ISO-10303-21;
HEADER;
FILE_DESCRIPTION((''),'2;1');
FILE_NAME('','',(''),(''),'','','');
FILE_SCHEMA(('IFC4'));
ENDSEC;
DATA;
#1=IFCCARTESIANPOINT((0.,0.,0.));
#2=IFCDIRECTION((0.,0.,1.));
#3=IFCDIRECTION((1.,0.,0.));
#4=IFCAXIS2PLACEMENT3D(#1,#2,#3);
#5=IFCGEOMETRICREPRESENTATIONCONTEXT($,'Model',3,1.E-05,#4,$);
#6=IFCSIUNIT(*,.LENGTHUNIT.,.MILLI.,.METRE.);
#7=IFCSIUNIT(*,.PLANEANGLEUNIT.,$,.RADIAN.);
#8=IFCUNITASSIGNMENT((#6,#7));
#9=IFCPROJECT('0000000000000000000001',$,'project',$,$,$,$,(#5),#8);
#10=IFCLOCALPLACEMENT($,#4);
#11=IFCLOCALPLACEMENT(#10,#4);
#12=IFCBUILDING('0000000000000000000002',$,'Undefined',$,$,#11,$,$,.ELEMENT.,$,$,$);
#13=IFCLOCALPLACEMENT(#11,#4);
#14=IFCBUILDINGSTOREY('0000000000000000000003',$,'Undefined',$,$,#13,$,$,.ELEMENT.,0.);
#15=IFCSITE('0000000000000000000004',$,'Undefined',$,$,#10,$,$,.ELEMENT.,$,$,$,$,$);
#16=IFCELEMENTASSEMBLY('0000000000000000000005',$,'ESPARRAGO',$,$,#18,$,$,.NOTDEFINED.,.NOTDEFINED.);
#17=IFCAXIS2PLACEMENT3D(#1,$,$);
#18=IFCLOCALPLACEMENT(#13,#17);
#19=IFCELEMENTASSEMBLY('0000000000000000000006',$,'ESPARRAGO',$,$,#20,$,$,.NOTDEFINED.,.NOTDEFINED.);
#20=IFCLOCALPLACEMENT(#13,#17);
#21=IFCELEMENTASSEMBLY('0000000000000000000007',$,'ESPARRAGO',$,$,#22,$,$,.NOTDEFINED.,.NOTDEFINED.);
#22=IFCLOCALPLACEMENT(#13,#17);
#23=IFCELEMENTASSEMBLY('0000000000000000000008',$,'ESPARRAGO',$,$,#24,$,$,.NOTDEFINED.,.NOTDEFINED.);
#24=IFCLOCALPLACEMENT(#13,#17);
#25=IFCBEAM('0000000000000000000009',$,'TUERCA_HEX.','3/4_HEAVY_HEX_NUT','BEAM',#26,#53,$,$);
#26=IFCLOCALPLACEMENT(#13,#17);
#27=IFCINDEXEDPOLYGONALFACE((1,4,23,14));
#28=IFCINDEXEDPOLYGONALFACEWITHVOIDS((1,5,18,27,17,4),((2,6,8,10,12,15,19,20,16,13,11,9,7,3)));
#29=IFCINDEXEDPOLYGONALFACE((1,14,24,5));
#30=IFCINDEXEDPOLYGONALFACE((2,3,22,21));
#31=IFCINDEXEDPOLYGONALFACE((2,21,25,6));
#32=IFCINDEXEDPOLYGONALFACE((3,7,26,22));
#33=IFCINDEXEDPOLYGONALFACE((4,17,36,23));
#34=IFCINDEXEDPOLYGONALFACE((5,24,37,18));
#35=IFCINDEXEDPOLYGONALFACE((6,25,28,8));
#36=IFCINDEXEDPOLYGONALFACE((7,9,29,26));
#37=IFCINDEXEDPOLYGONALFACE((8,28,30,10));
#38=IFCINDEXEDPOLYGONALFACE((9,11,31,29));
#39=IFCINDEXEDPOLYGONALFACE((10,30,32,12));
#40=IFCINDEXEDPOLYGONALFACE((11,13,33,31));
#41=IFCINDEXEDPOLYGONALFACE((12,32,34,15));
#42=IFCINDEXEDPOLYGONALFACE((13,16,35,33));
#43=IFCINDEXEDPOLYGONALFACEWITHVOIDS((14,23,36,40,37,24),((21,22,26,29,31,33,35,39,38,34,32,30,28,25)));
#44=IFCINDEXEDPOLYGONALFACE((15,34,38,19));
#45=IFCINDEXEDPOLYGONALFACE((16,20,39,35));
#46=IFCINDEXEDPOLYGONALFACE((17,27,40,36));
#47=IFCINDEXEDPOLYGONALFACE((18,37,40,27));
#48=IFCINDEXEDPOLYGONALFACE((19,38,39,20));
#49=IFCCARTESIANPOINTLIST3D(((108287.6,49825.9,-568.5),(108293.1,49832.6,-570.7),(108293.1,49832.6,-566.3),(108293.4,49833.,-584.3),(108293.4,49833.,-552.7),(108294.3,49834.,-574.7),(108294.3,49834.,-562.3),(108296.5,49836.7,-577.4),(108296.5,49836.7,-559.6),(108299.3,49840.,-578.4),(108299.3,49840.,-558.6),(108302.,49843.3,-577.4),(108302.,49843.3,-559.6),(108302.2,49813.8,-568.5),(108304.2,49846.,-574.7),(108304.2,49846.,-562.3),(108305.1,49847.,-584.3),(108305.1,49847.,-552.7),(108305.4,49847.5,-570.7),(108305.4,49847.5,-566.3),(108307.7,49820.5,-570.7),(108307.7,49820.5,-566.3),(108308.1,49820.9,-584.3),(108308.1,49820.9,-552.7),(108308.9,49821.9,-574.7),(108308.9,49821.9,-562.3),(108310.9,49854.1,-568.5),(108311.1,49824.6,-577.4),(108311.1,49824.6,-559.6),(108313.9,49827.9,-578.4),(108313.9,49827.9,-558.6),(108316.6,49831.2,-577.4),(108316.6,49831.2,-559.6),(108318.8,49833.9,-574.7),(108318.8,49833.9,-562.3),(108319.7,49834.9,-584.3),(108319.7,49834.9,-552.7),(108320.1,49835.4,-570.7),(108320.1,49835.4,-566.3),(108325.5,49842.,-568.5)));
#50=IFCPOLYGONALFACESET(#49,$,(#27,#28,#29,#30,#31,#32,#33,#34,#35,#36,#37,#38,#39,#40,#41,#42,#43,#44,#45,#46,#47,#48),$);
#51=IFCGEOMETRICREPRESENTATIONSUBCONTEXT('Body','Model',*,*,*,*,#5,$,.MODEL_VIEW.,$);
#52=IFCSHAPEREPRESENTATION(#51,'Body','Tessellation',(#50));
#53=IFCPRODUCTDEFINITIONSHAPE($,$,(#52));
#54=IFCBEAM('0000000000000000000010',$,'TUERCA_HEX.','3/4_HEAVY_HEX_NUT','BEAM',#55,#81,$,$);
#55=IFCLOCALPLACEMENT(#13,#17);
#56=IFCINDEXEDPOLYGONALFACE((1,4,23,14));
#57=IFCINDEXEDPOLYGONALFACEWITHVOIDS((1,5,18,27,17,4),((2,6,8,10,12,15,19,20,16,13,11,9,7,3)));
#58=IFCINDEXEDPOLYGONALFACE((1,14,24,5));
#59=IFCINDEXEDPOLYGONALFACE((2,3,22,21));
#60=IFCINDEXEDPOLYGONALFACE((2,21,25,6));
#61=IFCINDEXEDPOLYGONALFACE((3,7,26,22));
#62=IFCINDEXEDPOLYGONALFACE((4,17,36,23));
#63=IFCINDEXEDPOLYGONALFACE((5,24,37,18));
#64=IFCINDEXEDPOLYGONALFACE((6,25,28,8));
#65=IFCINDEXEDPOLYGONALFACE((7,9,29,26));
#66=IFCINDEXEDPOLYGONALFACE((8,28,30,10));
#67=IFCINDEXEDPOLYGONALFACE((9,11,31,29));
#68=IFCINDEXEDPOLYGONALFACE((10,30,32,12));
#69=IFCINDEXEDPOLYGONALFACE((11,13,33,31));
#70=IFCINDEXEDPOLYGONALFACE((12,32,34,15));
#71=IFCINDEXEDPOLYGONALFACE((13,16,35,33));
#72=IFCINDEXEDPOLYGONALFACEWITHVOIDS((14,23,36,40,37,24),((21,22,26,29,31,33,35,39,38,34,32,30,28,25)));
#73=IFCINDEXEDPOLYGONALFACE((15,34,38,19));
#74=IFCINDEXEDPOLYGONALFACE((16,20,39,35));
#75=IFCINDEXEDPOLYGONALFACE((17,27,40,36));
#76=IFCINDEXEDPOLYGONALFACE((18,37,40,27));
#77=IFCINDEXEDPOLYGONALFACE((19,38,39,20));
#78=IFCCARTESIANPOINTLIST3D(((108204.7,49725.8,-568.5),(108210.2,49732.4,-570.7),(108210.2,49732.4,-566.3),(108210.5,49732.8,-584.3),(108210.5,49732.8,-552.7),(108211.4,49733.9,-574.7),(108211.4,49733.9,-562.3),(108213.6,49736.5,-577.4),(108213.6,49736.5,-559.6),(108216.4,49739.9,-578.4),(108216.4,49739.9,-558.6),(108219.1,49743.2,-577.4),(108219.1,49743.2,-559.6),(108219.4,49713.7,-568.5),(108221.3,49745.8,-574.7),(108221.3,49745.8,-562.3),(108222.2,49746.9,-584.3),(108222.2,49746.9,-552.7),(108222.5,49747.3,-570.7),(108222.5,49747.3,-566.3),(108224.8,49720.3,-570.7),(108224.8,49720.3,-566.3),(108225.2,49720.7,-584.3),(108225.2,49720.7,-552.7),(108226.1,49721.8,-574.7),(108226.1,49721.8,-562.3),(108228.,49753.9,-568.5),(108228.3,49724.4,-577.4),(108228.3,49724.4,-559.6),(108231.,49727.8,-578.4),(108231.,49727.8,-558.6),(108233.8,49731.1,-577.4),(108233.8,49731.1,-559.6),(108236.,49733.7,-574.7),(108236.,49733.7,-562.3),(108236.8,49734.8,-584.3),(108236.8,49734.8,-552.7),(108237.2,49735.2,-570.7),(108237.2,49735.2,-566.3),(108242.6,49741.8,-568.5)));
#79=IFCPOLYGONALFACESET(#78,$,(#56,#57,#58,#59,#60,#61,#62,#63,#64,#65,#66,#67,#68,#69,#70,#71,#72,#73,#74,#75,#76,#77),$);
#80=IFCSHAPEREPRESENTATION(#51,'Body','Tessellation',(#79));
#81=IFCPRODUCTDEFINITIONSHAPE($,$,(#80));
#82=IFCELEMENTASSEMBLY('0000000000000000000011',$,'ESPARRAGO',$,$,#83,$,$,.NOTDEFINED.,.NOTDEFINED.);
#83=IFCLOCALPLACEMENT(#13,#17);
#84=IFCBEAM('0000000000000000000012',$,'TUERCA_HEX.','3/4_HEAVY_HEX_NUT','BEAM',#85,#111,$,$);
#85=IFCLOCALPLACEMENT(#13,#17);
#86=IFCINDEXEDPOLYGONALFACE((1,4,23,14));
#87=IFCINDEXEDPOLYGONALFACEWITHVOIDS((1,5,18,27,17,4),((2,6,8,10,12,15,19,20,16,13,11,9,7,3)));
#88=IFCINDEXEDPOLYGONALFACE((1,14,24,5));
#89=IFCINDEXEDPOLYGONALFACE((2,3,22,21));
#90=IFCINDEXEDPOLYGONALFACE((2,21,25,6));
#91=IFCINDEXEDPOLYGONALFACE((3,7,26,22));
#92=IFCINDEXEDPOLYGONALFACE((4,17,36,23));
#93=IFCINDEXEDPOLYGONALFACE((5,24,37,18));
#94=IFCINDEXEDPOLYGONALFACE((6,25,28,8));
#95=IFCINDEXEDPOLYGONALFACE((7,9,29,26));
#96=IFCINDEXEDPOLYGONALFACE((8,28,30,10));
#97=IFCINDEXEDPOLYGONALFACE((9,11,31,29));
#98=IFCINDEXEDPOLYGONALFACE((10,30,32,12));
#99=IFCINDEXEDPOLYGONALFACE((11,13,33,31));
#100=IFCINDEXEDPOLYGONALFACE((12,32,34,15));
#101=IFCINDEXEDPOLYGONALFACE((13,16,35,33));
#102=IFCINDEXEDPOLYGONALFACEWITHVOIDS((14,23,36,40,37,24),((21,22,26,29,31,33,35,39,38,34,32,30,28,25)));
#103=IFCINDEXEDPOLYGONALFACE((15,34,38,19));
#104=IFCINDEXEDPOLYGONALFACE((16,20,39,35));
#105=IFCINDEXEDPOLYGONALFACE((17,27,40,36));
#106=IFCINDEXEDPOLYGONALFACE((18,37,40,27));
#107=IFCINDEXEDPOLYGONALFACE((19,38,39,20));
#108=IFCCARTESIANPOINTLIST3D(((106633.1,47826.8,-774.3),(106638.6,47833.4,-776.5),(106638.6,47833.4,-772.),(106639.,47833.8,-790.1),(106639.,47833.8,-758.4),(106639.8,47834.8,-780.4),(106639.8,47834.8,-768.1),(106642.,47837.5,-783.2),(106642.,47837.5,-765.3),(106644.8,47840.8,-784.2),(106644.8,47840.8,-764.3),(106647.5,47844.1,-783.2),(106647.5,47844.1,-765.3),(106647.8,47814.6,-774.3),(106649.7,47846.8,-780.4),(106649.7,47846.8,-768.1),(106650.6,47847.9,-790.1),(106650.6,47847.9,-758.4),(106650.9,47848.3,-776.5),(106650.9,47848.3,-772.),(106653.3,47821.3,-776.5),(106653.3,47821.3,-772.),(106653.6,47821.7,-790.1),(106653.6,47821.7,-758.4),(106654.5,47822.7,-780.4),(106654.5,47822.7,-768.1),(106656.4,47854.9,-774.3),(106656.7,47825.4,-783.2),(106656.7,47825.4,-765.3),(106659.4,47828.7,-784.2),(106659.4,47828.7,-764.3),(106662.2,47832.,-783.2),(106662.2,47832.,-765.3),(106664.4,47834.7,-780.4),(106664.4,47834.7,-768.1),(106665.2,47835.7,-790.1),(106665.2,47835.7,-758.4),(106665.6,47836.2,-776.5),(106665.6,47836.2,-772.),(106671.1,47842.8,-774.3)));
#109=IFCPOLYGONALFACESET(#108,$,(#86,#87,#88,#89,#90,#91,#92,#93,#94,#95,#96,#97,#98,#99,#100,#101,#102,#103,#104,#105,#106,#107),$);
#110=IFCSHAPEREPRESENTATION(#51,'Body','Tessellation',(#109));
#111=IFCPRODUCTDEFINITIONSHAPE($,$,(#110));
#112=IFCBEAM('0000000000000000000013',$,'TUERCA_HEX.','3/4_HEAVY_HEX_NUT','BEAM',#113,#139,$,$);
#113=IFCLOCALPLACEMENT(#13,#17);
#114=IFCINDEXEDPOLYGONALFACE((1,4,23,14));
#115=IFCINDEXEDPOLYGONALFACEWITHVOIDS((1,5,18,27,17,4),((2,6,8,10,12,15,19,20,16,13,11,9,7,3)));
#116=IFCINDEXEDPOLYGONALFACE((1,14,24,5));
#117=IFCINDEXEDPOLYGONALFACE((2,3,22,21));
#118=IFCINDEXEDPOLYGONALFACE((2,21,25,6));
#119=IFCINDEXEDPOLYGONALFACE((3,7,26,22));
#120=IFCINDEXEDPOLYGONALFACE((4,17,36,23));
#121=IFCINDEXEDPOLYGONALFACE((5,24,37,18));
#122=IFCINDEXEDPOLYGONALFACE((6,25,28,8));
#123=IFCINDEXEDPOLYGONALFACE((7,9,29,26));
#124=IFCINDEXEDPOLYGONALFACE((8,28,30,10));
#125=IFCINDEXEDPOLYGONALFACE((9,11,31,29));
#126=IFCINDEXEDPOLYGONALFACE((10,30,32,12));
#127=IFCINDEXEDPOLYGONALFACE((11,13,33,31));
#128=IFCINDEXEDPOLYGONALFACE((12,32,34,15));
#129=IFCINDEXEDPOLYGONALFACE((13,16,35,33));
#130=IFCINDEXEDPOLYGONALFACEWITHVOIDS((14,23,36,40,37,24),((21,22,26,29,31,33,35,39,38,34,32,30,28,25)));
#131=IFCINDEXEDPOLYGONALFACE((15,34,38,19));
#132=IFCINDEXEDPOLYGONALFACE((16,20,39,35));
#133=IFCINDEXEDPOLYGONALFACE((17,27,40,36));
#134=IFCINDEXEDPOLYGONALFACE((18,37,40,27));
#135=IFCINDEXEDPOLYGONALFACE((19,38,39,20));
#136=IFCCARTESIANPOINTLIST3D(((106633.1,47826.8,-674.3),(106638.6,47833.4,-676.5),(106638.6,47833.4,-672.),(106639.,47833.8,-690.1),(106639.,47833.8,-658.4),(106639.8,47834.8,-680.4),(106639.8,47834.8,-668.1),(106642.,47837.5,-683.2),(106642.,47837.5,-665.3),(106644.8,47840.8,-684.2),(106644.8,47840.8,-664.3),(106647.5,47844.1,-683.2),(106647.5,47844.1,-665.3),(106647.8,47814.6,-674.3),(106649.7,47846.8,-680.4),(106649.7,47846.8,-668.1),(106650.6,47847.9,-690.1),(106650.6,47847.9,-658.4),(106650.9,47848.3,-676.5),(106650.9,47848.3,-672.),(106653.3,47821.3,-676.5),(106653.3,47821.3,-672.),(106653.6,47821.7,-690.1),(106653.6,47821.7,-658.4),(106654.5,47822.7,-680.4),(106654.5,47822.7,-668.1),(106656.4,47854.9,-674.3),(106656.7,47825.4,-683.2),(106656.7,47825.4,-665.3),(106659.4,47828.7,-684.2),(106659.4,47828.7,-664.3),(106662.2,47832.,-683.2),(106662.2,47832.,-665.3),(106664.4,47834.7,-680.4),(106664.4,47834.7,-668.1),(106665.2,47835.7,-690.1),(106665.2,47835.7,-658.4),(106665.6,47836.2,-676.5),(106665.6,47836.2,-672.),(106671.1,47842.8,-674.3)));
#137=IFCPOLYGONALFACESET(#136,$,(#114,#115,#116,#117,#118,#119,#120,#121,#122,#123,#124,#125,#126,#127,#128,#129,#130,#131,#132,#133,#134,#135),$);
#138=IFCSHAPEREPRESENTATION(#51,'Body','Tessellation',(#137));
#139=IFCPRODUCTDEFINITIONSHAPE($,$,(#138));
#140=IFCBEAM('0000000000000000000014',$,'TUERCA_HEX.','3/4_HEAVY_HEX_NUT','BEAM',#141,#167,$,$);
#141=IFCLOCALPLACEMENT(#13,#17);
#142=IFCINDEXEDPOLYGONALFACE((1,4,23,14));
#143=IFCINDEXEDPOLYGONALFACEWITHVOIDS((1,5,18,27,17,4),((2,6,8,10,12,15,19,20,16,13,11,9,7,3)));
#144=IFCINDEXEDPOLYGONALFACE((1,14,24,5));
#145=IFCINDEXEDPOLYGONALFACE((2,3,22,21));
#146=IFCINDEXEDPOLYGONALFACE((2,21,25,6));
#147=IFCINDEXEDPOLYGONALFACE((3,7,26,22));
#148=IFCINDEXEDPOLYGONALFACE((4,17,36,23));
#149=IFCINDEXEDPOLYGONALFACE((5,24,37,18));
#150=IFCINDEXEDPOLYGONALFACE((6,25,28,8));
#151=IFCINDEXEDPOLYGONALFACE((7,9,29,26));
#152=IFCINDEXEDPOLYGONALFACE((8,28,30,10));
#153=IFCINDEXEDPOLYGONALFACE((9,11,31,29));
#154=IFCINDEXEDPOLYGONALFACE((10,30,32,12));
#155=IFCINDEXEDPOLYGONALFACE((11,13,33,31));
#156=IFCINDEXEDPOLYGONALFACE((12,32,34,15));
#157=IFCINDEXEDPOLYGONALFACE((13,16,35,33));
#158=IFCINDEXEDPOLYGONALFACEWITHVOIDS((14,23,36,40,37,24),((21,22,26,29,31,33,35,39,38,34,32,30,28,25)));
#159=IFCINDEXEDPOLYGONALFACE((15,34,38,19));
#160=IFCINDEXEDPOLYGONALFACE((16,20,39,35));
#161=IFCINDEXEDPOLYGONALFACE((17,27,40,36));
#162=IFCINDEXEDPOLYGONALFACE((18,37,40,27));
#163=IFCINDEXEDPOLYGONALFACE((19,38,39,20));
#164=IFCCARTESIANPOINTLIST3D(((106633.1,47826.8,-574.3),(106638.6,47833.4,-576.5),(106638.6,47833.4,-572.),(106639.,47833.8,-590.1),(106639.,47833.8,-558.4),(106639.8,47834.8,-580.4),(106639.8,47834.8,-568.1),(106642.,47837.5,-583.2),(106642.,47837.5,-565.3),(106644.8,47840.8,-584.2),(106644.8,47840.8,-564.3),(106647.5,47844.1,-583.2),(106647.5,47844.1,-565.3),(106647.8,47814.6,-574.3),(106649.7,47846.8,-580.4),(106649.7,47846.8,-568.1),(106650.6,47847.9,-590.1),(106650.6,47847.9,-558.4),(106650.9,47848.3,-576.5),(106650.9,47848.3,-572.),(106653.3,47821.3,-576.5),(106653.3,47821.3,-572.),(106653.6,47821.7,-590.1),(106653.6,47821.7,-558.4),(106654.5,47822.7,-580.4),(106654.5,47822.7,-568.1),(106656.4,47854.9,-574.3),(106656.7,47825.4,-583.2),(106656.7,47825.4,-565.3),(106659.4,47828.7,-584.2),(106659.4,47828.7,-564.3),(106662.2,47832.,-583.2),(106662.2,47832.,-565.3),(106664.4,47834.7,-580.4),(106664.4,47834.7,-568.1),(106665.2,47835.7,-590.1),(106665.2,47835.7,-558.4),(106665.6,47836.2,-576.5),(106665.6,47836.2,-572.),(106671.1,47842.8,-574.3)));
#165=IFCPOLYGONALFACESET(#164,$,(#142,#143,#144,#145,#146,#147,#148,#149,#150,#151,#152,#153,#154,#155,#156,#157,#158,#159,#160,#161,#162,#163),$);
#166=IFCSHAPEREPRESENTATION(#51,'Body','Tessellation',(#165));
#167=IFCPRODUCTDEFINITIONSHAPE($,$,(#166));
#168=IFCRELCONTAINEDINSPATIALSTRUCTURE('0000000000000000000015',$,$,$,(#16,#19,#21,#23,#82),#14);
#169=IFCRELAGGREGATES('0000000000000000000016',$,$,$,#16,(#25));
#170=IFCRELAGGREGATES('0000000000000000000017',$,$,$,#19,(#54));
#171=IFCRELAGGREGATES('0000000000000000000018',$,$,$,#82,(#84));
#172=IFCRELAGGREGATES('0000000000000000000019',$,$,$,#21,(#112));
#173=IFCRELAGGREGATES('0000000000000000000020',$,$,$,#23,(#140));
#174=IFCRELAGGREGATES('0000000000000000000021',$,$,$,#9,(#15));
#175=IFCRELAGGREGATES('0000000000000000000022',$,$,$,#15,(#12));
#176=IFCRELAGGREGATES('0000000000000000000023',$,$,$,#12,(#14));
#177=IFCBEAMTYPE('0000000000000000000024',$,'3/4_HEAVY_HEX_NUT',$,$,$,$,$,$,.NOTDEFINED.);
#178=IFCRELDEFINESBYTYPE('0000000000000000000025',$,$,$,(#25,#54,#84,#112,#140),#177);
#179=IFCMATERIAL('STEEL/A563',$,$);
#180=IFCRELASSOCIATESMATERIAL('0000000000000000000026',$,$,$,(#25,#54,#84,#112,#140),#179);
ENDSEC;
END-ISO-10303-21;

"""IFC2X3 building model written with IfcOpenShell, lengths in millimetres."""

from ifc_helpers import new_model, si_unit, frame, origin_with_axes, place, context, subcontext, project, spatial, polyline, outline, extrude, material, type_object, element, aggregate, save


model = new_model("IFC2X3")

# Units and contexts
model_context = context("Model", 3, precision=1e-05, world=origin_with_axes())
body_context = subcontext(model_context, "Body", "Model", "MODEL_VIEW")
ifc_project = project(units=[si_unit("LENGTHUNIT", "METRE", prefix="MILLI"), si_unit("PLANEANGLEUNIT", "RADIAN")], contexts=[model_context])

# Site, building, storey
site_placement = place(None, origin_with_axes())
site = spatial("IfcSite", under=ifc_project, at=site_placement, Name="Undefined", CompositionType="ELEMENT")
building_placement = place(site_placement, origin_with_axes())
building = spatial("IfcBuilding", under=site, at=building_placement, Name="Undefined", CompositionType="ELEMENT")
storey_placement = place(building_placement, origin_with_axes())
storey = spatial("IfcBuildingStorey", under=building, at=storey_placement, Name="Undefined", CompositionType="ELEMENT", Elevation=0.0)

# Element assemblies
assembly_1_placement = place(storey_placement, origin_with_axes())
assembly_1 = element("IfcElementAssembly", 1, at=assembly_1_placement, inside=storey, Name="ESPARRAGO", AssemblyPlace="NOTDEFINED", PredefinedType="NOTDEFINED")
assembly_2_placement = place(storey_placement, origin_with_axes())
assembly_2 = element("IfcElementAssembly", 2, at=assembly_2_placement, inside=storey, Name="ESPARRAGO", AssemblyPlace="NOTDEFINED", PredefinedType="NOTDEFINED")
assembly_3_placement = place(storey_placement, origin_with_axes())
assembly_3 = element("IfcElementAssembly", 3, at=assembly_3_placement, inside=storey, Name="ESPARRAGO", AssemblyPlace="NOTDEFINED", PredefinedType="NOTDEFINED")
assembly_4_placement = place(storey_placement, origin_with_axes())
assembly_4 = element("IfcElementAssembly", 4, at=assembly_4_placement, inside=storey, Name="ESPARRAGO", AssemblyPlace="NOTDEFINED", PredefinedType="NOTDEFINED")

# Beams
ifc_material_1 = material(Name="STEEL/A563")
beam_type_1 = type_object("IfcBeamType", Name="3/4_HEAVY_HEX_NUT", PredefinedType="NOTDEFINED")
beam_1_placement = place(assembly_1_placement, frame((108299.3, 49840.0, -568.5), z_axis=(0.000012, -0.00001, 1.0), x_axis=(0.7704, -0.637561, -0.000016)))
beam_1 = element("IfcBeam", 5, at=beam_1_placement, type_object=beam_type_1, material=ifc_material_1, Name="TUERCA_HEX.", Description="3/4_HEAVY_HEX_NUT", ObjectType="BEAM", context=body_context, shape_type="SweptSolid", body=[
    extrude(outline(polyline([(9.1, -15.8), (-9.1, -15.8), (-18.3, 0.0), (-9.1, 15.8), (9.1, 15.8), (18.3, 0.0), (9.1, -15.8)]), holes=[polyline([(-4.3, 8.9), (-7.8, 6.2), (-9.7, 2.2), (-9.7, -2.2), (-7.8, -6.2), (-4.3, -8.9), (0.0, -9.9), (4.3, -8.9), (7.8, -6.2), (9.7, -2.2), (9.7, 2.2), (7.8, 6.2), (4.3, 8.9), (0.0, 9.9), (-4.3, 8.9)])]), frame((19.0, 0.0, 0.0), z_axis=(-1.0, 0.0, 0.0), x_axis=(0.0, -1.0, 0.0)), (0.0, 0.0, 1.0), 19.0),
])
beam_2_placement = place(assembly_2_placement, frame((108216.4, 49739.9, -568.5), z_axis=(0.000012, -0.00001, 1.0), x_axis=(0.7704, -0.637561, -0.000016)))
beam_2 = element("IfcBeam", 6, at=beam_2_placement, type_object=beam_type_1, material=ifc_material_1, Name="TUERCA_HEX.", Description="3/4_HEAVY_HEX_NUT", ObjectType="BEAM", context=body_context, shape_type="SweptSolid", body=[
    extrude(outline(polyline([(9.1, -15.8), (-9.1, -15.8), (-18.3, 0.0), (-9.1, 15.8), (9.1, 15.8), (18.3, 0.0), (9.1, -15.8)]), holes=[polyline([(-4.3, 8.9), (-7.8, 6.2), (-9.7, 2.2), (-9.7, -2.2), (-7.8, -6.2), (-4.3, -8.9), (0.0, -9.9), (4.3, -8.9), (7.8, -6.2), (9.7, -2.2), (9.7, 2.2), (7.8, 6.2), (4.3, 8.9), (0.0, 9.9), (-4.3, 8.9)])]), frame((19.0, 0.0, 0.0), z_axis=(-1.0, 0.0, 0.0), x_axis=(0.0, -1.0, 0.0)), (0.0, 0.0, 1.0), 19.0),
])

# Element assembly, beam
assembly_5_placement = place(storey_placement, origin_with_axes())
assembly_5 = element("IfcElementAssembly", 7, at=assembly_5_placement, inside=storey, Name="ESPARRAGO", AssemblyPlace="NOTDEFINED", PredefinedType="NOTDEFINED")
beam_3_placement = place(assembly_5_placement, frame((106644.8, 47840.8, -774.3), z_axis=(0.000012, -0.00001, 1.0), x_axis=(0.7704, -0.637561, -0.000016)))
beam_3 = element("IfcBeam", 8, at=beam_3_placement, type_object=beam_type_1, material=ifc_material_1, Name="TUERCA_HEX.", Description="3/4_HEAVY_HEX_NUT", ObjectType="BEAM", context=body_context, shape_type="SweptSolid", body=[
    extrude(outline(polyline([(9.1, -15.8), (-9.1, -15.8), (-18.3, 0.0), (-9.1, 15.8), (9.1, 15.8), (18.3, 0.0), (9.1, -15.8)]), holes=[polyline([(-4.3, 8.9), (-7.8, 6.2), (-9.7, 2.2), (-9.7, -2.2), (-7.8, -6.2), (-4.3, -8.9), (0.0, -9.9), (4.3, -8.9), (7.8, -6.2), (9.7, -2.2), (9.7, 2.2), (7.8, 6.2), (4.3, 8.9), (0.0, 9.9), (-4.3, 8.9)])]), frame((19.0, 0.0, 0.0), z_axis=(-1.0, 0.0, 0.0), x_axis=(0.0, -1.0, 0.0)), (0.0, 0.0, 1.0), 19.0),
])

# Beams
beam_4_placement = place(assembly_3_placement, frame((106644.8, 47840.8, -674.3), z_axis=(0.000012, -0.00001, 1.0), x_axis=(0.7704, -0.637561, -0.000016)))
beam_4 = element("IfcBeam", 9, at=beam_4_placement, type_object=beam_type_1, material=ifc_material_1, Name="TUERCA_HEX.", Description="3/4_HEAVY_HEX_NUT", ObjectType="BEAM", context=body_context, shape_type="SweptSolid", body=[
    extrude(outline(polyline([(9.1, -15.8), (-9.1, -15.8), (-18.3, 0.0), (-9.1, 15.8), (9.1, 15.8), (18.3, 0.0), (9.1, -15.8)]), holes=[polyline([(-4.3, 8.9), (-7.8, 6.2), (-9.7, 2.2), (-9.7, -2.2), (-7.8, -6.2), (-4.3, -8.9), (0.0, -9.9), (4.3, -8.9), (7.8, -6.2), (9.7, -2.2), (9.7, 2.2), (7.8, 6.2), (4.3, 8.9), (0.0, 9.9), (-4.3, 8.9)])]), frame((19.0, 0.0, 0.0), z_axis=(-1.0, 0.0, 0.0), x_axis=(0.0, -1.0, 0.0)), (0.0, 0.0, 1.0), 19.0),
])
beam_5_placement = place(assembly_4_placement, frame((106644.8, 47840.8, -574.3), z_axis=(0.000012, -0.00001, 1.0), x_axis=(0.7704, -0.637561, -0.000016)))
beam_5 = element("IfcBeam", 10, at=beam_5_placement, type_object=beam_type_1, material=ifc_material_1, Name="TUERCA_HEX.", Description="3/4_HEAVY_HEX_NUT", ObjectType="BEAM", context=body_context, shape_type="SweptSolid", body=[
    extrude(outline(polyline([(9.1, -15.8), (-9.1, -15.8), (-18.3, 0.0), (-9.1, 15.8), (9.1, 15.8), (18.3, 0.0), (9.1, -15.8)]), holes=[polyline([(-4.3, 8.9), (-7.8, 6.2), (-9.7, 2.2), (-9.7, -2.2), (-7.8, -6.2), (-4.3, -8.9), (0.0, -9.9), (4.3, -8.9), (7.8, -6.2), (9.7, -2.2), (9.7, 2.2), (7.8, 6.2), (4.3, 8.9), (0.0, 9.9), (-4.3, 8.9)])]), frame((19.0, 0.0, 0.0), z_axis=(-1.0, 0.0, 0.0), x_axis=(0.0, -1.0, 0.0)), (0.0, 0.0, 1.0), 19.0),
])
aggregate(assembly_1, [beam_1])
aggregate(assembly_2, [beam_2])
aggregate(assembly_5, [beam_3])
aggregate(assembly_3, [beam_4])
aggregate(assembly_4, [beam_5])

save(model, "model.ifc")
